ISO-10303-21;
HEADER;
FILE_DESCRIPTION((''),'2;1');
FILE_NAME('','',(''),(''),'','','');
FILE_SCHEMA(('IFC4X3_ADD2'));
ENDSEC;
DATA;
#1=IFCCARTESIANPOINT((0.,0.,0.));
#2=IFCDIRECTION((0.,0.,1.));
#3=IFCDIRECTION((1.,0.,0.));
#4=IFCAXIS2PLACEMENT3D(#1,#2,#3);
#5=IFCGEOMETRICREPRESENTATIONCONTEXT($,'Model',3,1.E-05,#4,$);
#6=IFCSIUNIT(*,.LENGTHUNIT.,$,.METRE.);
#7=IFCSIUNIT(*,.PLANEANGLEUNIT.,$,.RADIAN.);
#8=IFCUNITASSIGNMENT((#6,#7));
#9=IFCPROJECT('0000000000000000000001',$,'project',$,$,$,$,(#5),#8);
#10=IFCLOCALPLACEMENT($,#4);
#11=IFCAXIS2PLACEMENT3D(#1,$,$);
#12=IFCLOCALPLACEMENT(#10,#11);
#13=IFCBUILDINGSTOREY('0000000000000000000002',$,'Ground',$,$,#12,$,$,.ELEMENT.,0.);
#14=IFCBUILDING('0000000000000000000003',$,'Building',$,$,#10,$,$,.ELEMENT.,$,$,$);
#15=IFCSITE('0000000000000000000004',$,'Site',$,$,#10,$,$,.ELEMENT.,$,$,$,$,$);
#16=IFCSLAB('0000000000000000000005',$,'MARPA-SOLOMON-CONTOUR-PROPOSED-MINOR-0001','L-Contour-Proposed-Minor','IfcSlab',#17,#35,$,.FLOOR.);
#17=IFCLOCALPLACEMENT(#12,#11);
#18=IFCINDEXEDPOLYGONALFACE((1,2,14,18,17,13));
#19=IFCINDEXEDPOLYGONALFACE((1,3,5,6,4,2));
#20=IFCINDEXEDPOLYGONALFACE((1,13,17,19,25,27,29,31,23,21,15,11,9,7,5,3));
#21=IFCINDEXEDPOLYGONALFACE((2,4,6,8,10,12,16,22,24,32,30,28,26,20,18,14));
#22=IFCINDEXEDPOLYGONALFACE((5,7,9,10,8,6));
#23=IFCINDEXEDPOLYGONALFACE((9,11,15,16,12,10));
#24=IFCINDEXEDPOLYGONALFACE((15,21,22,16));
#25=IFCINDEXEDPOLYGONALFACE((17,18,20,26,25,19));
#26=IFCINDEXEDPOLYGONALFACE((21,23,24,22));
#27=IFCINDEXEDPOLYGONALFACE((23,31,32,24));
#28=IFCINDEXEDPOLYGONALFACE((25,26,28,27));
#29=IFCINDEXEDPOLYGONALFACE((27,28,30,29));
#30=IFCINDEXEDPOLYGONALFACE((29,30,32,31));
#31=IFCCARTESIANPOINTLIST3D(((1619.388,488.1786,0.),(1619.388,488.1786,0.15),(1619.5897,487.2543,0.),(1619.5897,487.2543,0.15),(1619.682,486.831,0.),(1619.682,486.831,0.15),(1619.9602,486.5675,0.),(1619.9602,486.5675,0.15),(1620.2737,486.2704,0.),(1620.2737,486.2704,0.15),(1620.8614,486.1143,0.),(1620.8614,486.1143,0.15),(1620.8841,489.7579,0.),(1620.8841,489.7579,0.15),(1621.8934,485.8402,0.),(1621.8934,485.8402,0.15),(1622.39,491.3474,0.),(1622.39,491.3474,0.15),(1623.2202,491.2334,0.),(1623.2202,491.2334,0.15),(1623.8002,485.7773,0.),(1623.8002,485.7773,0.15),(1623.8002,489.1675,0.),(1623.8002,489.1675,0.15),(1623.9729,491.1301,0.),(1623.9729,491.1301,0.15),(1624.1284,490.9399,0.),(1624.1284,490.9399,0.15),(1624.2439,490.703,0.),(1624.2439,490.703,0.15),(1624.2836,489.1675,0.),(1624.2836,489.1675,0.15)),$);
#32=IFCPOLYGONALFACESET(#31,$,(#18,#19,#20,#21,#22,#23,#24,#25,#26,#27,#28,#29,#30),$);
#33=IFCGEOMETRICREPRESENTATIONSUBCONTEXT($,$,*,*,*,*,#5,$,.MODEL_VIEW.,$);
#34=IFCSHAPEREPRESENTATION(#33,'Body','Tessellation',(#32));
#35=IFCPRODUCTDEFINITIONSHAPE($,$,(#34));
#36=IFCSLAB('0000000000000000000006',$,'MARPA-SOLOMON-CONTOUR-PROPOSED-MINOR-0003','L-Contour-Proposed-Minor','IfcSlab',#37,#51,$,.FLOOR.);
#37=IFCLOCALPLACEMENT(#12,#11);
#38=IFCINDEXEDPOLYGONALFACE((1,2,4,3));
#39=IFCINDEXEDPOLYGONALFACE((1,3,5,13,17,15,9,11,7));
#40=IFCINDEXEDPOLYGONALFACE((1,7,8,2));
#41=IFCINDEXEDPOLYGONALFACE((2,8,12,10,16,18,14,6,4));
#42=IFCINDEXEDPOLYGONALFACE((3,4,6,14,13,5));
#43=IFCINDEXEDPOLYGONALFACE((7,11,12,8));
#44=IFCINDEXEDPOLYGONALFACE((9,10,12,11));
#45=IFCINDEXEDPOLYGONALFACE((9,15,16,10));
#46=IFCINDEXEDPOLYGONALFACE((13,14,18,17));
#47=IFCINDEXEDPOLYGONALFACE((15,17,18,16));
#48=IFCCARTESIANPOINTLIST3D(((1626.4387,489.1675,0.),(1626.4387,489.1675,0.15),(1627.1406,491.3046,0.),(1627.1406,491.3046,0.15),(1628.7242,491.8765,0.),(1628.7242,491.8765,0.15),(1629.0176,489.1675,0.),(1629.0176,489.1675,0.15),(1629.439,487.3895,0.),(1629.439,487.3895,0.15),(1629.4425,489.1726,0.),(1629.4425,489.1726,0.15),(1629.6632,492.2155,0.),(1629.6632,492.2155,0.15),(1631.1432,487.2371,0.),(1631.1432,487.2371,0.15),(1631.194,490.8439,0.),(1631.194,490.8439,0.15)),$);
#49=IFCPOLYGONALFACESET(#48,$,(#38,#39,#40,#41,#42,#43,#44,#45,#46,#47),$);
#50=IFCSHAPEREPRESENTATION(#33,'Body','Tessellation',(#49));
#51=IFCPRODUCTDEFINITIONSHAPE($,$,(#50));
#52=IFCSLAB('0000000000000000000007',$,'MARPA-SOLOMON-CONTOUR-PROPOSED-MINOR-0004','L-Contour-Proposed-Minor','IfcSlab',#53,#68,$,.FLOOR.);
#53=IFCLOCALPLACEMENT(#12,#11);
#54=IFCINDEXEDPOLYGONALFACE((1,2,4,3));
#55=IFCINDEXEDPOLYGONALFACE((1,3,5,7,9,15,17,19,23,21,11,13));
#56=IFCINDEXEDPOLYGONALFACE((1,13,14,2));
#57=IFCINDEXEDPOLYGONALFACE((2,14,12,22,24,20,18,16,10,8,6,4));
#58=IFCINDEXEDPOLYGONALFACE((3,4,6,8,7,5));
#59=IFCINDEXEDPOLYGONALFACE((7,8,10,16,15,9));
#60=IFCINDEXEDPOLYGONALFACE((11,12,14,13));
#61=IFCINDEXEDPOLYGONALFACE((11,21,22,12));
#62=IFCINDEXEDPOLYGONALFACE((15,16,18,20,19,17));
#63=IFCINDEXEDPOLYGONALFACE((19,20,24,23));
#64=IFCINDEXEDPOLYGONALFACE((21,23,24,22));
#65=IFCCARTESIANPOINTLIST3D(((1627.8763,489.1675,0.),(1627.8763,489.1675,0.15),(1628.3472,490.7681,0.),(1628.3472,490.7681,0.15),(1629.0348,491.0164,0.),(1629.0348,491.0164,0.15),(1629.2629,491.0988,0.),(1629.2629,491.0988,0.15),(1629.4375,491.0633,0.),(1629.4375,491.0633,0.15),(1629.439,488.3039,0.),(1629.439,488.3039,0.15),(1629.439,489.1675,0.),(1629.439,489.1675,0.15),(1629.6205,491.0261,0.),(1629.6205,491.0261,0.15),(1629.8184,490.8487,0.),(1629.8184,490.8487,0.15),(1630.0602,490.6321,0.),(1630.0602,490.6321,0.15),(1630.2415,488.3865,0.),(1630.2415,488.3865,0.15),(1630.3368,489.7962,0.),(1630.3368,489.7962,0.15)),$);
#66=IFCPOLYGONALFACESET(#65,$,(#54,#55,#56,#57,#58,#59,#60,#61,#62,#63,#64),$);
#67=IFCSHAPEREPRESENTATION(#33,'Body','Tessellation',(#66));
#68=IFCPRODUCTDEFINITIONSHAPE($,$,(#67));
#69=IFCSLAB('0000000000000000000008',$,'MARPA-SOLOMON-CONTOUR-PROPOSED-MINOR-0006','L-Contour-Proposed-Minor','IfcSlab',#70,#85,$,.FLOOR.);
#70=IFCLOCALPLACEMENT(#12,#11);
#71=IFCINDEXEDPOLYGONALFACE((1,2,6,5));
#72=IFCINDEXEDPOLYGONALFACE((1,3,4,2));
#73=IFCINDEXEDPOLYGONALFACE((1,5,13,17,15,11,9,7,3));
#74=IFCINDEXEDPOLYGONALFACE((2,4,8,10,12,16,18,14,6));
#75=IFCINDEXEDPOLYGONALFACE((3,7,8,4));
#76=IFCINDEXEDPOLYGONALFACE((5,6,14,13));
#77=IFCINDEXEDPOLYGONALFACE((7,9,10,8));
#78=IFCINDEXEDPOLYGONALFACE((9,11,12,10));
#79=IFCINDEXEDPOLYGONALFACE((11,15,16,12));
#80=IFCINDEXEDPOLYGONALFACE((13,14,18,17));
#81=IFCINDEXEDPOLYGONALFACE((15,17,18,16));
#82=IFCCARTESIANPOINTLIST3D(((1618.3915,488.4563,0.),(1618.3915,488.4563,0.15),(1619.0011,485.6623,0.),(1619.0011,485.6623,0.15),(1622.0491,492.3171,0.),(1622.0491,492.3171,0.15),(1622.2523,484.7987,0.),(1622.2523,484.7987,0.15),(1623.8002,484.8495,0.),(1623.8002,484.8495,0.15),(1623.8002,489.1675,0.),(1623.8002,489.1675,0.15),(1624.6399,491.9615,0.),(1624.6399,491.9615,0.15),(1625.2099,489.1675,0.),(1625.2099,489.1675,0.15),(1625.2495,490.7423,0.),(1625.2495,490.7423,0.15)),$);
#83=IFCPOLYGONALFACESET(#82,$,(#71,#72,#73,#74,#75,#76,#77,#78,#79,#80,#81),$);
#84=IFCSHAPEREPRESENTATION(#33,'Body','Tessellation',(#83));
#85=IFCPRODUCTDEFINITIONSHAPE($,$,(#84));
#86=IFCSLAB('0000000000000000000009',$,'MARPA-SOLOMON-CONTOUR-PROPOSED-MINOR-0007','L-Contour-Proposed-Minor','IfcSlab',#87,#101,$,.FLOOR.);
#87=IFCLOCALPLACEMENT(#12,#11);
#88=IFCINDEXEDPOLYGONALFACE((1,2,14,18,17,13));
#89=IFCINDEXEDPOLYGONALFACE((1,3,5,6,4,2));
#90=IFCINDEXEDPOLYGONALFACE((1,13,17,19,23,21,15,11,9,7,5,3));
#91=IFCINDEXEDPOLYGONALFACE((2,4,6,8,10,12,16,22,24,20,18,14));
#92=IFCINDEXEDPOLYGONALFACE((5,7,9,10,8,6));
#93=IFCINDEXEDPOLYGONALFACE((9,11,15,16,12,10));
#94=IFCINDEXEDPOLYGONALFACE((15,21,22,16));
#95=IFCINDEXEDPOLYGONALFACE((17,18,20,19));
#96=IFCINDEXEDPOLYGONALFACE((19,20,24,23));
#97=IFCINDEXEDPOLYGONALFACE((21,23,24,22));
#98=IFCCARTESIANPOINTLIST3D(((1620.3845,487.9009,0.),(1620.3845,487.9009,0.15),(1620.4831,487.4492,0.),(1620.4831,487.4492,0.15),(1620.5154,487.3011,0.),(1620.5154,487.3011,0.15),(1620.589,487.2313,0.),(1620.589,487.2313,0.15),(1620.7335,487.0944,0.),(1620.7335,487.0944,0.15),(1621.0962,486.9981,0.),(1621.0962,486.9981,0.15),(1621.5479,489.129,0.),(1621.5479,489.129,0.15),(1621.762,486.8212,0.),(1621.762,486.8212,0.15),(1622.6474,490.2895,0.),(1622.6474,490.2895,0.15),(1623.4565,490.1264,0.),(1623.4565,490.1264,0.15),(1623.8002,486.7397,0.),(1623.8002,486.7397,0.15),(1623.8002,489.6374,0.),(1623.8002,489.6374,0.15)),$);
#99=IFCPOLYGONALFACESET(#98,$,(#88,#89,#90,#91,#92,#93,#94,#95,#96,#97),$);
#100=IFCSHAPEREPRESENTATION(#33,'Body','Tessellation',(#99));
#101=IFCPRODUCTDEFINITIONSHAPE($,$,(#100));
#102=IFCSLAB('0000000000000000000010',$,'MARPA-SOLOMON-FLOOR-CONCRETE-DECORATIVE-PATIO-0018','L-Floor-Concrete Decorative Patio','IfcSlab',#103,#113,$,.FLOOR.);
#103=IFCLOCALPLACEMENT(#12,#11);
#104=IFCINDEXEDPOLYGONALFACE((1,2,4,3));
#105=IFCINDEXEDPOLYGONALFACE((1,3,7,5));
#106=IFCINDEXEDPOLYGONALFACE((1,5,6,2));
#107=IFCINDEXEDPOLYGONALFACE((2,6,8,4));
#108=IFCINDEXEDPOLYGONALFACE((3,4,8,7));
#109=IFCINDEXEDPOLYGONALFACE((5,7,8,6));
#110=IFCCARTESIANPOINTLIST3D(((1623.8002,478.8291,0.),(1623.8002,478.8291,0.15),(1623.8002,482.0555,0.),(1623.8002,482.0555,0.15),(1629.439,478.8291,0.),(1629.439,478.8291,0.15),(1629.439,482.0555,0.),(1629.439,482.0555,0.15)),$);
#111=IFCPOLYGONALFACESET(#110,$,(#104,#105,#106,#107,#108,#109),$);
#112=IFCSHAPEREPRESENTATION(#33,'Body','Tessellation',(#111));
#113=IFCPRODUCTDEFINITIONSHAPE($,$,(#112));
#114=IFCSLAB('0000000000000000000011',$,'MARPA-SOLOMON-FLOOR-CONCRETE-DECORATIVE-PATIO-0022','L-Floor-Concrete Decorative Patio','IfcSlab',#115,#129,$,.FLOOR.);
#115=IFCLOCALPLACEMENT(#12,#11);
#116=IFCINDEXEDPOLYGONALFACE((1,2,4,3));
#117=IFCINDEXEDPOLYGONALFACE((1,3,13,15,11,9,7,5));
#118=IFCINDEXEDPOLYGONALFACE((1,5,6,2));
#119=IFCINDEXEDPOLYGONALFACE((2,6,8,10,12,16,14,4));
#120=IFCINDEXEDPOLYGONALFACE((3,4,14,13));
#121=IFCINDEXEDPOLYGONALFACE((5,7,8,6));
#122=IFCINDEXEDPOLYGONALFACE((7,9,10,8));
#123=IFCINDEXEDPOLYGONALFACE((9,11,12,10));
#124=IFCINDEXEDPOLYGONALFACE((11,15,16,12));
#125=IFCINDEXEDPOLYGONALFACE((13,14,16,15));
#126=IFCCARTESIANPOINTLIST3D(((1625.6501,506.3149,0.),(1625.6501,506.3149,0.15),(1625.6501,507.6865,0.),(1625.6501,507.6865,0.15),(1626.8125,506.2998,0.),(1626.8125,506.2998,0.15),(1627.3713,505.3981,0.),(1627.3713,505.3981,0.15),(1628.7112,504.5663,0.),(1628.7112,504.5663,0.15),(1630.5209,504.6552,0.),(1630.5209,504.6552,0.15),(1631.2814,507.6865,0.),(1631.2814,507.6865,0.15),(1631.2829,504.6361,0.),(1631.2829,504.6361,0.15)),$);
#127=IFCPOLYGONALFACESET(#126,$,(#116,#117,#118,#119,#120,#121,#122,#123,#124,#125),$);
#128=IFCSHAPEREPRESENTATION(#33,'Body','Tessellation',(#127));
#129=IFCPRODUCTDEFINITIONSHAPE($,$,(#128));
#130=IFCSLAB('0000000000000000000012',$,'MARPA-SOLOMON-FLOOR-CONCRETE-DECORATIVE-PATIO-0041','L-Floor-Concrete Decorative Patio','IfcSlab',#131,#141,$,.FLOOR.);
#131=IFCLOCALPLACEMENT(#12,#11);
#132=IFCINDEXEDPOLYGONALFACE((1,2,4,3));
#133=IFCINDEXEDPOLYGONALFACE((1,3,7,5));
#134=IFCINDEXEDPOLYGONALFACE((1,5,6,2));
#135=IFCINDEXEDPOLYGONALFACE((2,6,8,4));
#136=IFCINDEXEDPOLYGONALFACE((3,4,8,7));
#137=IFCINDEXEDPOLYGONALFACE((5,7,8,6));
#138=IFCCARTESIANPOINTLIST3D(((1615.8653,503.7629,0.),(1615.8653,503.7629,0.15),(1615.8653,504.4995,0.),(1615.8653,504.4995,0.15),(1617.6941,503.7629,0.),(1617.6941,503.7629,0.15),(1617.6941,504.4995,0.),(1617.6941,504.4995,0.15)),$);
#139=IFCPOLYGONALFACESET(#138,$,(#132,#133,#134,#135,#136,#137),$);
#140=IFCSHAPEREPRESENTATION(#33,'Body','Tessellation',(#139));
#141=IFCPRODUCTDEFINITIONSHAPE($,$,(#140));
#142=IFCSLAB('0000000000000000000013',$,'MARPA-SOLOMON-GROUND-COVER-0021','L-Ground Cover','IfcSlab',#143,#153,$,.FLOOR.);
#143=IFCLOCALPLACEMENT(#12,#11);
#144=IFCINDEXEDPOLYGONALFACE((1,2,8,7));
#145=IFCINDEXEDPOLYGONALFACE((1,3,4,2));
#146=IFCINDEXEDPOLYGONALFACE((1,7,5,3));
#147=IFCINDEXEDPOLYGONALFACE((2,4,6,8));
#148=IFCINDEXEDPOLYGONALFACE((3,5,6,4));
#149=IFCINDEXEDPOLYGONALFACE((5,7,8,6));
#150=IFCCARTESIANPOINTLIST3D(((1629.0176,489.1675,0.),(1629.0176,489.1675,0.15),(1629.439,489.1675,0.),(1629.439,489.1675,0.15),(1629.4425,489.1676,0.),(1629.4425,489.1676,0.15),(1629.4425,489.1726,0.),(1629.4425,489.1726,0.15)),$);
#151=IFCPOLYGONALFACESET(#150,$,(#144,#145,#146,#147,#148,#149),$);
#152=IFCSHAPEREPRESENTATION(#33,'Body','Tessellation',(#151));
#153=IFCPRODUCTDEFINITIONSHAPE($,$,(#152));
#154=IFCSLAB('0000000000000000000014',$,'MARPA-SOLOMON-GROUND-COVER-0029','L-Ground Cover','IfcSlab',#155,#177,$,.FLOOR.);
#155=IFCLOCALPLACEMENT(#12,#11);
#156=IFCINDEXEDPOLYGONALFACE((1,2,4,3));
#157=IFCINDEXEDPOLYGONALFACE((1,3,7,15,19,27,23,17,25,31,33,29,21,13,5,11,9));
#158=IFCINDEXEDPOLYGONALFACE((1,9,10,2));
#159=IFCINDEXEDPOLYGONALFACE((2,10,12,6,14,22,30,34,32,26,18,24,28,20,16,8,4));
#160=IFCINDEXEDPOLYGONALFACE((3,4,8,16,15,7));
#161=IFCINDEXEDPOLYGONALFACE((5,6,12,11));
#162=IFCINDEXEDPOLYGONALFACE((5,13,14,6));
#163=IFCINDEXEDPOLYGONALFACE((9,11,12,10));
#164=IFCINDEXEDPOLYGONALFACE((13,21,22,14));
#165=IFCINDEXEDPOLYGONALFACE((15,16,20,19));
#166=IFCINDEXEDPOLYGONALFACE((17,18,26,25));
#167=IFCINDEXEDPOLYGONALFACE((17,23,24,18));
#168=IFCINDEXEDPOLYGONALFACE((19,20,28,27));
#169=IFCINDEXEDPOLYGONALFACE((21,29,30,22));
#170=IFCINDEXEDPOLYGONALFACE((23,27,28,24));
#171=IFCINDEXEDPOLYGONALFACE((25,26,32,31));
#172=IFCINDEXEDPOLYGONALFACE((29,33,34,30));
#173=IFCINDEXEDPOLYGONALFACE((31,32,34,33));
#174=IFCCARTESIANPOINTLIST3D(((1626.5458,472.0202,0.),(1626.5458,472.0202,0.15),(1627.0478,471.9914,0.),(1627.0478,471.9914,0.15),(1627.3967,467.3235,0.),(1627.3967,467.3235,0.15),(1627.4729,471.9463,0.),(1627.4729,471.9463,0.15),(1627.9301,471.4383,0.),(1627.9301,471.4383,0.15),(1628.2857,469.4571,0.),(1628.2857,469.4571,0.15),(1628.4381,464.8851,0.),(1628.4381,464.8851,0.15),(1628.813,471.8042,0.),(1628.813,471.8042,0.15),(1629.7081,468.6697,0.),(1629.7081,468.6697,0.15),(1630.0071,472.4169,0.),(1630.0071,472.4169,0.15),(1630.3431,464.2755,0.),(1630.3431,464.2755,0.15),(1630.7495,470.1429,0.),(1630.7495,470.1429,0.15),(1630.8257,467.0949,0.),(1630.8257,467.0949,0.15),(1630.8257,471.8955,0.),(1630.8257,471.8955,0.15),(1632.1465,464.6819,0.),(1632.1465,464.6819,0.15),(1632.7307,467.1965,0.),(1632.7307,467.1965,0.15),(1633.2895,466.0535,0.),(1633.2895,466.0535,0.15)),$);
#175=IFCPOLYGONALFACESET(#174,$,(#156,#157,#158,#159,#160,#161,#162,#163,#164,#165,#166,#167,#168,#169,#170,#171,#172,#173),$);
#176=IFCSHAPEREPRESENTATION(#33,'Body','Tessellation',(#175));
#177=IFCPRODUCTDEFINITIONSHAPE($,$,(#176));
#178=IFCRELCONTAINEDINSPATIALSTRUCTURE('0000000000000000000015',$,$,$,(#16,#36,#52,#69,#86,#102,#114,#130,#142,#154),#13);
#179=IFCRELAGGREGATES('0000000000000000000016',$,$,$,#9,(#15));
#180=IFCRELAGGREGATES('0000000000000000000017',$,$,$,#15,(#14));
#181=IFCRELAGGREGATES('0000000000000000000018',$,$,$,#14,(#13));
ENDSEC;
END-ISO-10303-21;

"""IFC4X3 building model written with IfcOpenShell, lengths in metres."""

from ifc_helpers import new_model, si_unit, frame, origin, origin_with_axes, place, context, subcontext, project, spatial, polyline, outline, extrude, element, save


model = new_model("IFC4X3")

# Units and contexts
model_context = context("Model", 3, precision=1e-05, world=origin_with_axes())
sub_context = subcontext(model_context, None, None, "MODEL_VIEW")
ifc_project = project(units=[si_unit("LENGTHUNIT", "METRE"), si_unit("PLANEANGLEUNIT", "RADIAN")], contexts=[model_context])

# Site, building, storey
placement = place(None, origin_with_axes())
site = spatial("IfcSite", under=ifc_project, at=placement, Name="Site", CompositionType="ELEMENT")
building = spatial("IfcBuilding", under=site, at=placement, Name="Building", CompositionType="ELEMENT")
storey_placement = place(placement, origin())
storey = spatial("IfcBuildingStorey", under=building, at=storey_placement, Name="Ground", CompositionType="ELEMENT", Elevation=0.0)

# Slabs
slab_1_placement = place(storey_placement, frame((1619.388, 485.7773, 0.0)))
element("IfcSlab", 1, at=slab_1_placement, inside=storey, Name="MARPA-SOLOMON-CONTOUR-PROPOSED-MINOR-0001", Description="L-Contour-Proposed-Minor", ObjectType="IfcSlab", PredefinedType="FLOOR", context=sub_context, shape_type="SweptSolid", body=[
    extrude(outline(polyline([(4.4122, 0.0), (2.5054, 0.0629), (1.4734, 0.337), (0.8857, 0.4931), (0.5722, 0.7901), (0.294, 1.0536), (0.2017, 1.4769), (0.0, 2.4013), (1.4961, 3.9806), (3.002, 5.5701), (3.8322, 5.4561), (4.5849, 5.3528), (4.7404, 5.1625), (4.8559, 4.9257), (4.8956, 3.3902), (4.4122, 3.3902), (4.4122, 0.0)])), origin(), (0.0, 0.0, 1.0), 0.15),
])
slab_2_placement = place(storey_placement, frame((1626.4387, 487.2371, 0.0)))
element("IfcSlab", 2, at=slab_2_placement, inside=storey, Name="MARPA-SOLOMON-CONTOUR-PROPOSED-MINOR-0003", Description="L-Contour-Proposed-Minor", ObjectType="IfcSlab", PredefinedType="FLOOR", context=sub_context, shape_type="SweptSolid", body=[
    extrude(outline(polyline([(2.2855, 4.6393), (0.702, 4.0674), (0.0, 1.9304), (2.5789, 1.9304), (3.0038, 1.9354), (3.0003, 0.1524), (4.7045, 0.0), (4.7553, 3.6068), (3.2245, 4.9784), (2.2855, 4.6393)])), origin(), (0.0, 0.0, 1.0), 0.15),
])
slab_3_placement = place(storey_placement, frame((1627.8763, 488.3039, 0.0)))
element("IfcSlab", 3, at=slab_3_placement, inside=storey, Name="MARPA-SOLOMON-CONTOUR-PROPOSED-MINOR-0004", Description="L-Contour-Proposed-Minor", ObjectType="IfcSlab", PredefinedType="FLOOR", context=sub_context, shape_type="SweptSolid", body=[
    extrude(outline(polyline([(2.3652, 0.0826), (2.4605, 1.4923), (2.1839, 2.3281), (1.9421, 2.5448), (1.7442, 2.7221), (1.5612, 2.7593), (1.3866, 2.7948), (1.1585, 2.7125), (0.4709, 2.4641), (0.0, 0.8636), (1.5627, 0.8636), (1.5627, 0.0), (2.3652, 0.0826)])), origin(), (0.0, 0.0, 1.0), 0.15),
])
slab_4_placement = place(storey_placement, frame((1618.3915, 484.7987, 0.0)))
element("IfcSlab", 4, at=slab_4_placement, inside=storey, Name="MARPA-SOLOMON-CONTOUR-PROPOSED-MINOR-0006", Description="L-Contour-Proposed-Minor", ObjectType="IfcSlab", PredefinedType="FLOOR", context=sub_context, shape_type="SweptSolid", body=[
    extrude(outline(polyline([(5.4087, 0.0508), (3.8608, 0.0), (0.6096, 0.8636), (0.0, 3.6576), (3.6576, 7.5184), (6.2484, 7.1628), (6.858, 5.9436), (6.8184, 4.3688), (5.4087, 4.3688), (5.4087, 0.0508)])), origin(), (0.0, 0.0, 1.0), 0.15),
])
slab_5_placement = place(storey_placement, frame((1620.3845, 486.7397, 0.0)))
element("IfcSlab", 5, at=slab_5_placement, inside=storey, Name="MARPA-SOLOMON-CONTOUR-PROPOSED-MINOR-0007", Description="L-Contour-Proposed-Minor", ObjectType="IfcSlab", PredefinedType="FLOOR", context=sub_context, shape_type="SweptSolid", body=[
    extrude(outline(polyline([(3.4157, 0.0), (1.3775, 0.0815), (0.7117, 0.2583), (0.349, 0.3547), (0.2045, 0.4915), (0.1309, 0.5613), (0.0986, 0.7095), (0.0, 1.1612), (1.1634, 2.3893), (2.2629, 3.5498), (3.072, 3.3867), (3.4157, 2.8977), (3.4157, 0.0)])), origin(), (0.0, 0.0, 1.0), 0.15),
])
slab_6_placement = place(storey_placement, frame((1623.8002, 478.8291, 0.0)))
element("IfcSlab", 6, at=slab_6_placement, inside=storey, Name="MARPA-SOLOMON-FLOOR-CONCRETE-DECORATIVE-PATIO-0018", Description="L-Floor-Concrete Decorative Patio", ObjectType="IfcSlab", PredefinedType="FLOOR", context=sub_context, shape_type="SweptSolid", body=[
    extrude(outline(polyline([(0.0, 3.2264), (5.6388, 3.2264), (5.6388, 0.0), (0.0, 0.0), (0.0, 3.2264)])), origin(), (0.0, 0.0, 1.0), 0.15),
])
slab_7_placement = place(storey_placement, frame((1625.6501, 504.5663, 0.0)))
element("IfcSlab", 7, at=slab_7_placement, inside=storey, Name="MARPA-SOLOMON-FLOOR-CONCRETE-DECORATIVE-PATIO-0022", Description="L-Floor-Concrete Decorative Patio", ObjectType="IfcSlab", PredefinedType="FLOOR", context=sub_context, shape_type="SweptSolid", body=[
    extrude(outline(polyline([(0.0, 3.1202), (0.0, 1.7486), (1.1625, 1.7335), (1.7213, 0.8319), (3.0611, 0.0), (4.8709, 0.0889), (5.6329, 0.0699), (5.6313, 3.1202), (0.0, 3.1202)])), origin(), (0.0, 0.0, 1.0), 0.15),
])
slab_8_placement = place(storey_placement, frame((1615.8653, 503.7629, 0.0)))
element("IfcSlab", 8, at=slab_8_placement, inside=storey, Name="MARPA-SOLOMON-FLOOR-CONCRETE-DECORATIVE-PATIO-0041", Description="L-Floor-Concrete Decorative Patio", ObjectType="IfcSlab", PredefinedType="FLOOR", context=sub_context, shape_type="SweptSolid", body=[
    extrude(outline(polyline([(0.0, 0.7366), (1.8288, 0.7366), (1.8288, 0.0), (0.0, 0.0), (0.0, 0.7366)])), origin(), (0.0, 0.0, 1.0), 0.15),
])
slab_9_placement = place(storey_placement, frame((1629.0176, 489.1675, 0.0)))
element("IfcSlab", 9, at=slab_9_placement, inside=storey, Name="MARPA-SOLOMON-GROUND-COVER-0021", Description="L-Ground Cover", ObjectType="IfcSlab", PredefinedType="FLOOR", context=sub_context, shape_type="SweptSolid", body=[
    extrude(outline(polyline([(0.4249, 0.0), (0.4249, 0.005), (0.0, 0.0), (0.4214, 0.0), (0.4249, 0.0)])), origin(), (0.0, 0.0, 1.0), 0.15),
])
slab_10_placement = place(storey_placement, frame((1626.5458, 464.2755, 0.0)))
element("IfcSlab", 10, at=slab_10_placement, inside=storey, Name="MARPA-SOLOMON-GROUND-COVER-0029", Description="L-Ground Cover", ObjectType="IfcSlab", PredefinedType="FLOOR", context=sub_context, shape_type="SweptSolid", body=[
    extrude(outline(polyline([(3.4613, 8.1413), (2.2672, 7.5287), (0.9271, 7.6708), (0.5019, 7.7159), (0.0, 7.7446), (1.3843, 7.1628), (1.7399, 5.1816), (0.8509, 3.048), (1.8923, 0.6096), (3.7973, 0.0), (5.6007, 0.4064), (6.7437, 1.778), (6.1849, 2.921), (4.2799, 2.8194), (3.1623, 4.3942), (4.2037, 5.8674), (4.2799, 7.62), (3.4613, 8.1413)])), origin(), (0.0, 0.0, 1.0), 0.15),
])

save(model, "model.ifc")
